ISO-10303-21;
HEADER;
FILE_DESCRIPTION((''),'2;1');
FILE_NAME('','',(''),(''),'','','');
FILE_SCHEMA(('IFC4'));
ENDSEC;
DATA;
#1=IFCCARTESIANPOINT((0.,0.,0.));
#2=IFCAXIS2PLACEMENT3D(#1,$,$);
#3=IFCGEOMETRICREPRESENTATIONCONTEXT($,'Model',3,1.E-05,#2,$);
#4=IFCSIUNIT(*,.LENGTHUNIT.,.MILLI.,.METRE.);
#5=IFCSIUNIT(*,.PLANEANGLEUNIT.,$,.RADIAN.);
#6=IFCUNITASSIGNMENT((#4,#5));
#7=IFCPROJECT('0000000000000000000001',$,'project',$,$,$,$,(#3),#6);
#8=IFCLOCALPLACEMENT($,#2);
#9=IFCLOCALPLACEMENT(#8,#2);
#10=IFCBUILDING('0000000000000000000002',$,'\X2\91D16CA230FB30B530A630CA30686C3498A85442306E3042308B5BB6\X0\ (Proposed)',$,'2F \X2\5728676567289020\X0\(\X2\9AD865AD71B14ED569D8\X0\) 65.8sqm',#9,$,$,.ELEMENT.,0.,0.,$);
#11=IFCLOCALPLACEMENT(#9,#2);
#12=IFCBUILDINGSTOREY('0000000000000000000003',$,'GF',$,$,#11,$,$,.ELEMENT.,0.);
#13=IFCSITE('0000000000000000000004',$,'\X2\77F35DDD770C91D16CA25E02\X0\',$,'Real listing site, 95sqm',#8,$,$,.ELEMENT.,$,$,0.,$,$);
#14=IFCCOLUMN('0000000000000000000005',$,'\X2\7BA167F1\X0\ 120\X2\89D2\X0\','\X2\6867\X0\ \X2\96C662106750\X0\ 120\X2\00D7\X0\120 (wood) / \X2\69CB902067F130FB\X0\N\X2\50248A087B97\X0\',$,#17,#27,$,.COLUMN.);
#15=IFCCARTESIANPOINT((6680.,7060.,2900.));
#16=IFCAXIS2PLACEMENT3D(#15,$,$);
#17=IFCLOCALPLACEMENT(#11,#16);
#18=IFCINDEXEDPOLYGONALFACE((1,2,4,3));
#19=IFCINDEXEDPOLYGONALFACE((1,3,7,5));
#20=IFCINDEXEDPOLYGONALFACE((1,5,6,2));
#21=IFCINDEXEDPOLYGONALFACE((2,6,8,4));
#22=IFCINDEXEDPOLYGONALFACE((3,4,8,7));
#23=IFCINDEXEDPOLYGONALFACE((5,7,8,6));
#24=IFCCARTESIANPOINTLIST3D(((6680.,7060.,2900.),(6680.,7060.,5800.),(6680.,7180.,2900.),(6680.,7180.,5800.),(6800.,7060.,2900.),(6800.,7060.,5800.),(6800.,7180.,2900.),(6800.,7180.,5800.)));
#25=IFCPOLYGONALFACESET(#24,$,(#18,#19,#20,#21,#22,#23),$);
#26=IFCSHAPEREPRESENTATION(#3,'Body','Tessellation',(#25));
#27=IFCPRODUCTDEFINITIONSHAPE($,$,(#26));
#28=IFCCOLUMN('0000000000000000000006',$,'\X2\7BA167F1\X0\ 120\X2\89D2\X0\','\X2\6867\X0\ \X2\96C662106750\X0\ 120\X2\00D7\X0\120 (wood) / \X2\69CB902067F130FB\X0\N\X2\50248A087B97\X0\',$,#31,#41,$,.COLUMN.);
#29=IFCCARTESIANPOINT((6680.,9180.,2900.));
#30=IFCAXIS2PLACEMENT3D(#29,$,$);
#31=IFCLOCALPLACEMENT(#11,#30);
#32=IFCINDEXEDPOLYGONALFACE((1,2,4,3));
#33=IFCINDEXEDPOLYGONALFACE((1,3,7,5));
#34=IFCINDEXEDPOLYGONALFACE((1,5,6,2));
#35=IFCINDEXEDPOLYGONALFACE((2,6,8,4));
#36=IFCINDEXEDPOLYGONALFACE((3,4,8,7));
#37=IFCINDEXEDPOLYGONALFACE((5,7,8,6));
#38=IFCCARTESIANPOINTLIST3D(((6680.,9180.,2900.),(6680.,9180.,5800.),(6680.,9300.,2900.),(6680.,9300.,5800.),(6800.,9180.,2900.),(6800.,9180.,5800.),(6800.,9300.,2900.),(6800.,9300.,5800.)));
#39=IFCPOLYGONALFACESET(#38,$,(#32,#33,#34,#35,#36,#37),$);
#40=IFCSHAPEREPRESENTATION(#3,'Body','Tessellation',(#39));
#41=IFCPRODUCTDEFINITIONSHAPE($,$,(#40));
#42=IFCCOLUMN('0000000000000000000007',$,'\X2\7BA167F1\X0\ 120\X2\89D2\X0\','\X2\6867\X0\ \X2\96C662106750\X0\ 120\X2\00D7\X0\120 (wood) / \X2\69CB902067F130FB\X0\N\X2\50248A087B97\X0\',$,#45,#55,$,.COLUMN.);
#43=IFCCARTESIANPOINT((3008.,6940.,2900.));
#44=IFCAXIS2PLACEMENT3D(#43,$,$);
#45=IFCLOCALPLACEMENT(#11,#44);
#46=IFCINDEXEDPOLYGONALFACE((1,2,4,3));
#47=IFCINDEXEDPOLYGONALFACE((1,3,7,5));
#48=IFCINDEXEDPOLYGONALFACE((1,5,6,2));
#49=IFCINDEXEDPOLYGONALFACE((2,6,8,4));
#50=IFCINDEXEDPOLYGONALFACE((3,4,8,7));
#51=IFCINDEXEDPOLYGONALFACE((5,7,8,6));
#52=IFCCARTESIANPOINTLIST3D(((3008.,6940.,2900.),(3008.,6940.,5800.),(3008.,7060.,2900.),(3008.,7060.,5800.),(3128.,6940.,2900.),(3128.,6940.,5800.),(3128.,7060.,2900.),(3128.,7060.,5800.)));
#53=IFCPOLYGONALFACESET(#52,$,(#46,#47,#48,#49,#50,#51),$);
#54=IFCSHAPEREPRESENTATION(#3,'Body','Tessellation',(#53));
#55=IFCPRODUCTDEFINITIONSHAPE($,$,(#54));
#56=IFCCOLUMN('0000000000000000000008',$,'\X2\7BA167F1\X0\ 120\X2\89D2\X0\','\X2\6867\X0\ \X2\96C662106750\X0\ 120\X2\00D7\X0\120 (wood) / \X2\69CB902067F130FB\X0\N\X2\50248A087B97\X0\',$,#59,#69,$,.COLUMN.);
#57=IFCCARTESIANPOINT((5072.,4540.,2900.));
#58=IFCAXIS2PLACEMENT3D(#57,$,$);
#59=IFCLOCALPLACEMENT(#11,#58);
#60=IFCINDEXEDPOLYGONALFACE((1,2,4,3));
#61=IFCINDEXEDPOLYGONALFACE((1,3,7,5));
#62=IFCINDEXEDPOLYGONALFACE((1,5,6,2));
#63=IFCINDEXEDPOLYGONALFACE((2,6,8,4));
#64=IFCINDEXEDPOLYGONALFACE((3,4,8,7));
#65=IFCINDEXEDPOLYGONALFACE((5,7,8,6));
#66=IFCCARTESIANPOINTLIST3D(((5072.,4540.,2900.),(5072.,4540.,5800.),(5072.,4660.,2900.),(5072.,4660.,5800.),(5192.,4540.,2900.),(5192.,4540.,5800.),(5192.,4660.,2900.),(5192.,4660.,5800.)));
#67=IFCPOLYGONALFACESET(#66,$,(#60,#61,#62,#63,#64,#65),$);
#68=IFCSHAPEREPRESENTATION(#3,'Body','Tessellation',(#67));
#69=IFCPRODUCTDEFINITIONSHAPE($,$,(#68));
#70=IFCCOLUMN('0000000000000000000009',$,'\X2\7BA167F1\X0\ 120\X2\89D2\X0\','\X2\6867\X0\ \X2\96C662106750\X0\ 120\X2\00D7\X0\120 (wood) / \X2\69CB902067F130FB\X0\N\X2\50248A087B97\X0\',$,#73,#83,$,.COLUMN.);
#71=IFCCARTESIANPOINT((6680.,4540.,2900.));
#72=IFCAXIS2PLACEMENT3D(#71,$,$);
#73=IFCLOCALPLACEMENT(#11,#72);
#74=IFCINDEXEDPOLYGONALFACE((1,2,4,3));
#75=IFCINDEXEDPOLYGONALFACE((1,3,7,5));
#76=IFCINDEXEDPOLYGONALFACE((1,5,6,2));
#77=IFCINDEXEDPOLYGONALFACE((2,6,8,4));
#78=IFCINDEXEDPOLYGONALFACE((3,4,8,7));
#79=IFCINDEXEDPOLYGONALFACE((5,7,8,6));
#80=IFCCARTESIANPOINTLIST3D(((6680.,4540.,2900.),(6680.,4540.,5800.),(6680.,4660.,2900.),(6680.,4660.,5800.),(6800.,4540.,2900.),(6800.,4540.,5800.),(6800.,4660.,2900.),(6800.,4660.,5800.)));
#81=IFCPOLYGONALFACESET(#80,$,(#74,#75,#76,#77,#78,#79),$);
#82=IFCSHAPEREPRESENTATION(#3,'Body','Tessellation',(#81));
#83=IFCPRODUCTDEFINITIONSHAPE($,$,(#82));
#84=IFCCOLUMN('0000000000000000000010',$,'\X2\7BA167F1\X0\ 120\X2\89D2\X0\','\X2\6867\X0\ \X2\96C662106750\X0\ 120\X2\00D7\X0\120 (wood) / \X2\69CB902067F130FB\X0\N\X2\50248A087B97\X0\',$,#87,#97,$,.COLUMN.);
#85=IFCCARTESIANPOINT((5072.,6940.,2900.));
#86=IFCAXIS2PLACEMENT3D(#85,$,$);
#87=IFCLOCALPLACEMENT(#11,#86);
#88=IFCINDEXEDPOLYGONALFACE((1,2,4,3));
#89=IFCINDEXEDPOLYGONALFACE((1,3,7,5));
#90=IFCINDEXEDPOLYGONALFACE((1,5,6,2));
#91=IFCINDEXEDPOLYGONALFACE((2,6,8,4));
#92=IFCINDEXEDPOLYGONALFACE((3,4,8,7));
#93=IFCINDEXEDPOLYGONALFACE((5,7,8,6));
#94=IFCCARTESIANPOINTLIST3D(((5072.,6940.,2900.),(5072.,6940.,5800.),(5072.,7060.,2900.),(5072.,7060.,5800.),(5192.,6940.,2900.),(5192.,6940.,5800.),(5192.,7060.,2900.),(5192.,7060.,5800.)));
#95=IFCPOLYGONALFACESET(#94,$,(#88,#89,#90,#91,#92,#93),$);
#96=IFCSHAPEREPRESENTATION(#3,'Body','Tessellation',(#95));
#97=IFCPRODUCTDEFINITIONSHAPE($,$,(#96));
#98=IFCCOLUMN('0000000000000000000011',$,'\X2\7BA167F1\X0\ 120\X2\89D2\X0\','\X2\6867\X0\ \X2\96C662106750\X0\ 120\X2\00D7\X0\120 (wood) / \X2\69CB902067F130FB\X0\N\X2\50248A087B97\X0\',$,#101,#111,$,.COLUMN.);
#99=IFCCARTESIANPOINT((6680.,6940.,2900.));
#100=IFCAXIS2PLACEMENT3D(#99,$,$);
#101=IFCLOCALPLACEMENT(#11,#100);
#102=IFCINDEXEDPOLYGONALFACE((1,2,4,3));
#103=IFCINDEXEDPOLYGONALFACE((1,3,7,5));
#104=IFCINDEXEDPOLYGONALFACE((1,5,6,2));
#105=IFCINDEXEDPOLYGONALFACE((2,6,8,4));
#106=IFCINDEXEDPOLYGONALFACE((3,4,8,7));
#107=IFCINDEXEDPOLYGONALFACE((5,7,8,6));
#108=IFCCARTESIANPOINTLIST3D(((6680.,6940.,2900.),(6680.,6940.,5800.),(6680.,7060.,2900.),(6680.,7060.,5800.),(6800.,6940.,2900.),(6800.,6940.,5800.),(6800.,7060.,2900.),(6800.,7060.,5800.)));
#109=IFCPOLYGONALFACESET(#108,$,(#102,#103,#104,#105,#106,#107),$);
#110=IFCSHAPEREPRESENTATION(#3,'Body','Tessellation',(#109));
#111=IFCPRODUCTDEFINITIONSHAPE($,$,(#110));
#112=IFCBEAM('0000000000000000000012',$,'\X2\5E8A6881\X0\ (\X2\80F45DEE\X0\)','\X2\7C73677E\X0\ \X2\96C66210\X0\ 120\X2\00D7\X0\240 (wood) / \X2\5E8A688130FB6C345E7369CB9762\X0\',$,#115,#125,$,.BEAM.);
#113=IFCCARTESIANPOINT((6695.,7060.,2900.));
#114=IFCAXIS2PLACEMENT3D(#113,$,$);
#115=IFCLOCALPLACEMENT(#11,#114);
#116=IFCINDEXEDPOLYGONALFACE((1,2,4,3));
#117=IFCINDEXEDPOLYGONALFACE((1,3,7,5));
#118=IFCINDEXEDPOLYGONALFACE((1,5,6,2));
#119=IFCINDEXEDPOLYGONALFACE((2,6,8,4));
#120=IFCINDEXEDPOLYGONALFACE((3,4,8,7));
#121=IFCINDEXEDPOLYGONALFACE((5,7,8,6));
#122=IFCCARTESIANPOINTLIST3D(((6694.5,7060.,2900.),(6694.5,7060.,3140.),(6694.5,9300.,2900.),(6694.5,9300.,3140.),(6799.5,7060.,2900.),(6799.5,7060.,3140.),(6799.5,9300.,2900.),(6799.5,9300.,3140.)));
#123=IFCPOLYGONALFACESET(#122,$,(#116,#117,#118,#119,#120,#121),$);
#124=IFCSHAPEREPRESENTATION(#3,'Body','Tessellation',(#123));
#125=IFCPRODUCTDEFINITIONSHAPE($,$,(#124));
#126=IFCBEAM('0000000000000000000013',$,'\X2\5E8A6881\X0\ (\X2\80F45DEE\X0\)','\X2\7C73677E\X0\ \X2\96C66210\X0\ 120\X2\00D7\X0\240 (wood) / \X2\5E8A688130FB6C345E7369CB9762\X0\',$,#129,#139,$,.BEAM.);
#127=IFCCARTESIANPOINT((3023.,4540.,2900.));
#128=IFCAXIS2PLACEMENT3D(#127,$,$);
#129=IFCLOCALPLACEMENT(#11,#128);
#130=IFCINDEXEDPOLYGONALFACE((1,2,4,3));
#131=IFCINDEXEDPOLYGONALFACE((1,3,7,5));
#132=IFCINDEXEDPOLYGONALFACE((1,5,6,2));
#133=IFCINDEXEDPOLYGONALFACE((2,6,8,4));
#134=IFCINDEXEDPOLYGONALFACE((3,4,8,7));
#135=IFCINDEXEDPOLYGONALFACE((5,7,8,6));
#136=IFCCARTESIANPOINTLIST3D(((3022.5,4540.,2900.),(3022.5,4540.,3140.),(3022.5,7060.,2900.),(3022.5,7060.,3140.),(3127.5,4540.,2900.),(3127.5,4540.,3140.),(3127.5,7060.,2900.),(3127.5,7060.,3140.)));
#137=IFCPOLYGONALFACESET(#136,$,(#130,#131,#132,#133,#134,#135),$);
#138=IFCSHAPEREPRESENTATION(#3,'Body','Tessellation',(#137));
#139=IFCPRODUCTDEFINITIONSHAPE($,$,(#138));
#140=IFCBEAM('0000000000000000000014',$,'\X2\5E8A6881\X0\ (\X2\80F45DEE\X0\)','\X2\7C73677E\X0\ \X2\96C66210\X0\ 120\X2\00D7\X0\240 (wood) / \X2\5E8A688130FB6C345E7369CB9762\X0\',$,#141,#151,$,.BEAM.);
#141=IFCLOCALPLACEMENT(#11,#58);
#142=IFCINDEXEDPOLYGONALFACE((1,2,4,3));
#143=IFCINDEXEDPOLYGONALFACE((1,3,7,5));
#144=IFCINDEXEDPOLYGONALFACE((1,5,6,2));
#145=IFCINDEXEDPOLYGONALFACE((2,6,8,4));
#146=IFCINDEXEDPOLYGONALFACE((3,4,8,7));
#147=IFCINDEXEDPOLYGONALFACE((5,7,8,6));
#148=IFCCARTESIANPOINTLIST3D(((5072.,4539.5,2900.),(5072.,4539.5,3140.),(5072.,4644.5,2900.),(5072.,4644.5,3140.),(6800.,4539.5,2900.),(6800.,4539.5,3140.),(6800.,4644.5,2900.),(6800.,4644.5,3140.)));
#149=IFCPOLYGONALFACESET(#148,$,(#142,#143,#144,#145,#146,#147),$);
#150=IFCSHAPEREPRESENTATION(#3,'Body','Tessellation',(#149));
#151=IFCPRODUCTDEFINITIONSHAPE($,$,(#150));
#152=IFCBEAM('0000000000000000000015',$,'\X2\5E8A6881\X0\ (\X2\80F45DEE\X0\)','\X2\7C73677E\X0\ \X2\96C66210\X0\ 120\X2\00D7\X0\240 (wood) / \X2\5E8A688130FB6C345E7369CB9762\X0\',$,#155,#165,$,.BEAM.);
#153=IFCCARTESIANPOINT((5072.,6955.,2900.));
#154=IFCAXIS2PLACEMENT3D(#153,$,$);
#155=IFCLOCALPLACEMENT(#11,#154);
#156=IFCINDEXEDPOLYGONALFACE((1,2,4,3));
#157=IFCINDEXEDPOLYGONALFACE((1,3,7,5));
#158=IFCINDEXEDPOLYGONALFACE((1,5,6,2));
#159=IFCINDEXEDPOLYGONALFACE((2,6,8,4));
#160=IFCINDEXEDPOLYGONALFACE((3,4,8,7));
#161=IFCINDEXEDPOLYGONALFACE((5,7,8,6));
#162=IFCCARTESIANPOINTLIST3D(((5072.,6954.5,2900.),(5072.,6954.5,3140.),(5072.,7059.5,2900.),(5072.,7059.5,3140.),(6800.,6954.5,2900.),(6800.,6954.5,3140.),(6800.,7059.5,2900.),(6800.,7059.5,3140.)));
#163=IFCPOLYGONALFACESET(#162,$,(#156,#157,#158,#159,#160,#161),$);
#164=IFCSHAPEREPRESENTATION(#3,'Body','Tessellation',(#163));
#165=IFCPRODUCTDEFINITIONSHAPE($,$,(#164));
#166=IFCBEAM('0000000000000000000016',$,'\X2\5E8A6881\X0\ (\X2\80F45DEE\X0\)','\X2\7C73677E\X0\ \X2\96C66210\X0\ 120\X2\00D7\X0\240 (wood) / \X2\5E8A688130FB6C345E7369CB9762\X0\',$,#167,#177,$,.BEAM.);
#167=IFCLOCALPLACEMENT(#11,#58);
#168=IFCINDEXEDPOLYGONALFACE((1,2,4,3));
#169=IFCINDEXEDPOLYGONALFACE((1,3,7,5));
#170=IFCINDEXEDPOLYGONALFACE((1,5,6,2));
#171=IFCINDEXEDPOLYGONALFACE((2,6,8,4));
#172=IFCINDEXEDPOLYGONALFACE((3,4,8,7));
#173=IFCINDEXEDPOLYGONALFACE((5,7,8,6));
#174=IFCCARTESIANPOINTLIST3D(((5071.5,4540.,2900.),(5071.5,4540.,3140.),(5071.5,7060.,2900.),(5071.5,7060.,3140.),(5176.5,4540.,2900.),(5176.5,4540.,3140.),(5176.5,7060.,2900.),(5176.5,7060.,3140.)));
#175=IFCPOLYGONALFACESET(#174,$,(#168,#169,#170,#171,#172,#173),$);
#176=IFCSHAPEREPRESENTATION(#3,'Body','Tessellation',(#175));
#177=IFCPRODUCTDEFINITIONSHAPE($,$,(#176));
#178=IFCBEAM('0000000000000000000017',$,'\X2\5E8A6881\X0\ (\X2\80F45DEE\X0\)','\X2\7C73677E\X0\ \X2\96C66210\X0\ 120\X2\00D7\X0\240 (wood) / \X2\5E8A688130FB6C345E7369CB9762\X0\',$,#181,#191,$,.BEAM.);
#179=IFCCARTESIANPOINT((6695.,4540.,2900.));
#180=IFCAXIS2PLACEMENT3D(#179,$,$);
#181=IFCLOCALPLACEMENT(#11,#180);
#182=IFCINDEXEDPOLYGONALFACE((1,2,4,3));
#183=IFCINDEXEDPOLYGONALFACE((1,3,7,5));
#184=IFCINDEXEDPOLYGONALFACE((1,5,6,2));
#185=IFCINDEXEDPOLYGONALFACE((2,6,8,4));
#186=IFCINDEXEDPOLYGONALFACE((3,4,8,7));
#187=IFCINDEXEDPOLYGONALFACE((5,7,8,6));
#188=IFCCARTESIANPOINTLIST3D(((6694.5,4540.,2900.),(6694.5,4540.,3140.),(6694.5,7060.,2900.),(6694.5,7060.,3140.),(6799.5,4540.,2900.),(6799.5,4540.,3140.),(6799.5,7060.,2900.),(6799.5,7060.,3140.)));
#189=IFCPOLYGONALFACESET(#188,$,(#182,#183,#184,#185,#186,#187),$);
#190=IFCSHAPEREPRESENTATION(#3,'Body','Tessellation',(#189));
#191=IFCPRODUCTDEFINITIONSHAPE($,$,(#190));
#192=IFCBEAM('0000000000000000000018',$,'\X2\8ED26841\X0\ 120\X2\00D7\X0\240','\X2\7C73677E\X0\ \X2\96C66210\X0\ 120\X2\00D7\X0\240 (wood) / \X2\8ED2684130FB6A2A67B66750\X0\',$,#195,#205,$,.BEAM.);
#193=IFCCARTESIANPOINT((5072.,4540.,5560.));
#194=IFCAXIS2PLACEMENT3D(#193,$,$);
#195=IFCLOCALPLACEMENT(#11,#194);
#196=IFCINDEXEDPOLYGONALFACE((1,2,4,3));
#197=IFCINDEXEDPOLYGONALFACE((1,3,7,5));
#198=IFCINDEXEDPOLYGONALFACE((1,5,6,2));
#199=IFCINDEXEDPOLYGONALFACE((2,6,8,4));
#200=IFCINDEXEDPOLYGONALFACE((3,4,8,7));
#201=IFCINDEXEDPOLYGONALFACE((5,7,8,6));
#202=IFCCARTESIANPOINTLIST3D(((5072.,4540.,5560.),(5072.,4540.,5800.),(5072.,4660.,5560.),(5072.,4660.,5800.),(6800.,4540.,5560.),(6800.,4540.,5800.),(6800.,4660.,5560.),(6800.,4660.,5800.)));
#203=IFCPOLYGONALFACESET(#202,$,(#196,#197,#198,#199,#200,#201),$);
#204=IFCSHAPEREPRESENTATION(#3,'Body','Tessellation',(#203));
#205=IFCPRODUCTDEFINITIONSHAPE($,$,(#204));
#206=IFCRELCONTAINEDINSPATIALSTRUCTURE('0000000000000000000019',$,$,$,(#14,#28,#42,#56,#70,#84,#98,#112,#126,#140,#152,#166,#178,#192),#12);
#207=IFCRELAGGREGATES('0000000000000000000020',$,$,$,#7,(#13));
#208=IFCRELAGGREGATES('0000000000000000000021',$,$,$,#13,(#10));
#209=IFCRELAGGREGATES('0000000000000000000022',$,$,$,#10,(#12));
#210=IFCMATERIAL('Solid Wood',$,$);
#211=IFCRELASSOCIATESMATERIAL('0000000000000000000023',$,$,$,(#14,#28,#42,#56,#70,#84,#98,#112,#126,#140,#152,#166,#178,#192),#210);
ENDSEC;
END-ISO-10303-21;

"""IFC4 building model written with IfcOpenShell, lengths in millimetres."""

from ifc_helpers import new_model, si_unit, frame, frame_2d, origin, place, context, project, spatial, rectangle, extrude, material, element, save


model = new_model("IFC4")

# Units and contexts
model_context = context("Model", 3, precision=1e-05, world=origin())
ifc_project = project(units=[si_unit("LENGTHUNIT", "METRE", prefix="MILLI"), si_unit("PLANEANGLEUNIT", "RADIAN")], contexts=[model_context])

# Site, building, storey
site_placement = place(None, origin())
site = spatial("IfcSite", under=ifc_project, at=site_placement, Name="石川県金沢市", ObjectType="Real listing site, 95sqm", CompositionType="ELEMENT", RefElevation=0.0)
building_placement = place(site_placement, origin())
building = spatial("IfcBuilding", under=site, at=building_placement, Name="金沢・サウナと水風呂のある家 (Proposed)", ObjectType="2F 在来木造(高断熱仕様) 65.8sqm", CompositionType="ELEMENT", ElevationOfRefHeight=0.0, ElevationOfTerrain=0.0)
storey_placement = place(building_placement, origin())
storey = spatial("IfcBuildingStorey", under=building, at=storey_placement, Name="GF", CompositionType="ELEMENT", Elevation=0.0)

# Columns
ifc_material_1 = material(Name="Solid Wood")
column_1_placement = place(storey_placement, frame((6680.0, 7060.0, 2900.0)))
element("IfcColumn", 1, at=column_1_placement, inside=storey, material=ifc_material_1, Name="管柱 120角", Description="桧 集成材 120×120 (wood) / 構造柱・N値計算", PredefinedType="COLUMN", context=model_context, shape_type="SweptSolid", body=[
    extrude(rectangle(XDim=120.0, YDim=120.0, at=frame_2d((60.0, 60.0))), frame((6680.0, 7060.0, 2900.0)), (0.0, 0.0, 1.0), 2900.0),
])
column_2_placement = place(storey_placement, frame((6680.0, 9180.0, 2900.0)))
element("IfcColumn", 2, at=column_2_placement, inside=storey, material=ifc_material_1, Name="管柱 120角", Description="桧 集成材 120×120 (wood) / 構造柱・N値計算", PredefinedType="COLUMN", context=model_context, shape_type="SweptSolid", body=[
    extrude(rectangle(XDim=120.0, YDim=120.0, at=frame_2d((60.0, 60.0))), frame((6680.0, 9180.0, 2900.0)), (0.0, 0.0, 1.0), 2900.0),
])
column_3_placement = place(storey_placement, frame((3008.0, 6940.0, 2900.0)))
element("IfcColumn", 3, at=column_3_placement, inside=storey, material=ifc_material_1, Name="管柱 120角", Description="桧 集成材 120×120 (wood) / 構造柱・N値計算", PredefinedType="COLUMN", context=model_context, shape_type="SweptSolid", body=[
    extrude(rectangle(XDim=120.0, YDim=120.0, at=frame_2d((60.0, 60.0))), frame((3008.0, 6940.0, 2900.0)), (0.0, 0.0, 1.0), 2900.0),
])
column_4_placement = place(storey_placement, frame((5072.0, 4540.0, 2900.0)))
element("IfcColumn", 4, at=column_4_placement, inside=storey, material=ifc_material_1, Name="管柱 120角", Description="桧 集成材 120×120 (wood) / 構造柱・N値計算", PredefinedType="COLUMN", context=model_context, shape_type="SweptSolid", body=[
    extrude(rectangle(XDim=120.0, YDim=120.0, at=frame_2d((60.0, 60.0))), frame((5072.0, 4540.0, 2900.0)), (0.0, 0.0, 1.0), 2900.0),
])
column_5_placement = place(storey_placement, frame((6680.0, 4540.0, 2900.0)))
element("IfcColumn", 5, at=column_5_placement, inside=storey, material=ifc_material_1, Name="管柱 120角", Description="桧 集成材 120×120 (wood) / 構造柱・N値計算", PredefinedType="COLUMN", context=model_context, shape_type="SweptSolid", body=[
    extrude(rectangle(XDim=120.0, YDim=120.0, at=frame_2d((60.0, 60.0))), frame((6680.0, 4540.0, 2900.0)), (0.0, 0.0, 1.0), 2900.0),
])
column_6_placement = place(storey_placement, frame((5072.0, 6940.0, 2900.0)))
element("IfcColumn", 6, at=column_6_placement, inside=storey, material=ifc_material_1, Name="管柱 120角", Description="桧 集成材 120×120 (wood) / 構造柱・N値計算", PredefinedType="COLUMN", context=model_context, shape_type="SweptSolid", body=[
    extrude(rectangle(XDim=120.0, YDim=120.0, at=frame_2d((60.0, 60.0))), frame((5072.0, 6940.0, 2900.0)), (0.0, 0.0, 1.0), 2900.0),
])
column_7_placement = place(storey_placement, frame((6680.0, 6940.0, 2900.0)))
element("IfcColumn", 7, at=column_7_placement, inside=storey, material=ifc_material_1, Name="管柱 120角", Description="桧 集成材 120×120 (wood) / 構造柱・N値計算", PredefinedType="COLUMN", context=model_context, shape_type="SweptSolid", body=[
    extrude(rectangle(XDim=120.0, YDim=120.0, at=frame_2d((60.0, 60.0))), frame((6680.0, 6940.0, 2900.0)), (0.0, 0.0, 1.0), 2900.0),
])

# Beams
beam_1_placement = place(storey_placement, frame((6695.0, 7060.0, 2900.0)))
element("IfcBeam", 8, at=beam_1_placement, inside=storey, material=ifc_material_1, Name="床梁 (胴差)", Description="米松 集成 120×240 (wood) / 床梁・水平構面", PredefinedType="BEAM", context=model_context, shape_type="SweptSolid", body=[
    extrude(rectangle(XDim=105.0, YDim=2240.0, at=frame_2d((52.0, 1120.0))), frame((6695.0, 7060.0, 2900.0)), (0.0, 0.0, 1.0), 240.0),
])
beam_2_placement = place(storey_placement, frame((3023.0, 4540.0, 2900.0)))
element("IfcBeam", 9, at=beam_2_placement, inside=storey, material=ifc_material_1, Name="床梁 (胴差)", Description="米松 集成 120×240 (wood) / 床梁・水平構面", PredefinedType="BEAM", context=model_context, shape_type="SweptSolid", body=[
    extrude(rectangle(XDim=105.0, YDim=2520.0, at=frame_2d((52.0, 1260.0))), frame((3023.0, 4540.0, 2900.0)), (0.0, 0.0, 1.0), 240.0),
])
beam_3_placement = place(storey_placement, frame((5072.0, 4540.0, 2900.0)))
element("IfcBeam", 10, at=beam_3_placement, inside=storey, material=ifc_material_1, Name="床梁 (胴差)", Description="米松 集成 120×240 (wood) / 床梁・水平構面", PredefinedType="BEAM", context=model_context, shape_type="SweptSolid", body=[
    extrude(rectangle(XDim=1728.0, YDim=105.0, at=frame_2d((864.0, 52.0))), frame((5072.0, 4540.0, 2900.0)), (0.0, 0.0, 1.0), 240.0),
])
beam_4_placement = place(storey_placement, frame((5072.0, 6955.0, 2900.0)))
element("IfcBeam", 11, at=beam_4_placement, inside=storey, material=ifc_material_1, Name="床梁 (胴差)", Description="米松 集成 120×240 (wood) / 床梁・水平構面", PredefinedType="BEAM", context=model_context, shape_type="SweptSolid", body=[
    extrude(rectangle(XDim=1728.0, YDim=105.0, at=frame_2d((864.0, 52.0))), frame((5072.0, 6955.0, 2900.0)), (0.0, 0.0, 1.0), 240.0),
])
beam_5_placement = place(storey_placement, frame((5072.0, 4540.0, 2900.0)))
element("IfcBeam", 12, at=beam_5_placement, inside=storey, material=ifc_material_1, Name="床梁 (胴差)", Description="米松 集成 120×240 (wood) / 床梁・水平構面", PredefinedType="BEAM", context=model_context, shape_type="SweptSolid", body=[
    extrude(rectangle(XDim=105.0, YDim=2520.0, at=frame_2d((52.0, 1260.0))), frame((5072.0, 4540.0, 2900.0)), (0.0, 0.0, 1.0), 240.0),
])
beam_6_placement = place(storey_placement, frame((6695.0, 4540.0, 2900.0)))
element("IfcBeam", 13, at=beam_6_placement, inside=storey, material=ifc_material_1, Name="床梁 (胴差)", Description="米松 集成 120×240 (wood) / 床梁・水平構面", PredefinedType="BEAM", context=model_context, shape_type="SweptSolid", body=[
    extrude(rectangle(XDim=105.0, YDim=2520.0, at=frame_2d((52.0, 1260.0))), frame((6695.0, 4540.0, 2900.0)), (0.0, 0.0, 1.0), 240.0),
])
beam_7_placement = place(storey_placement, frame((5072.0, 4540.0, 5560.0)))
element("IfcBeam", 14, at=beam_7_placement, inside=storey, material=ifc_material_1, Name="軒桁 120×240", Description="米松 集成 120×240 (wood) / 軒桁・横架材", PredefinedType="BEAM", context=model_context, shape_type="SweptSolid", body=[
    extrude(rectangle(XDim=1728.0, YDim=120.0, at=frame_2d((864.0, 60.0))), frame((5072.0, 4540.0, 5560.0)), (0.0, 0.0, 1.0), 240.0),
])

save(model, "model.ifc")
